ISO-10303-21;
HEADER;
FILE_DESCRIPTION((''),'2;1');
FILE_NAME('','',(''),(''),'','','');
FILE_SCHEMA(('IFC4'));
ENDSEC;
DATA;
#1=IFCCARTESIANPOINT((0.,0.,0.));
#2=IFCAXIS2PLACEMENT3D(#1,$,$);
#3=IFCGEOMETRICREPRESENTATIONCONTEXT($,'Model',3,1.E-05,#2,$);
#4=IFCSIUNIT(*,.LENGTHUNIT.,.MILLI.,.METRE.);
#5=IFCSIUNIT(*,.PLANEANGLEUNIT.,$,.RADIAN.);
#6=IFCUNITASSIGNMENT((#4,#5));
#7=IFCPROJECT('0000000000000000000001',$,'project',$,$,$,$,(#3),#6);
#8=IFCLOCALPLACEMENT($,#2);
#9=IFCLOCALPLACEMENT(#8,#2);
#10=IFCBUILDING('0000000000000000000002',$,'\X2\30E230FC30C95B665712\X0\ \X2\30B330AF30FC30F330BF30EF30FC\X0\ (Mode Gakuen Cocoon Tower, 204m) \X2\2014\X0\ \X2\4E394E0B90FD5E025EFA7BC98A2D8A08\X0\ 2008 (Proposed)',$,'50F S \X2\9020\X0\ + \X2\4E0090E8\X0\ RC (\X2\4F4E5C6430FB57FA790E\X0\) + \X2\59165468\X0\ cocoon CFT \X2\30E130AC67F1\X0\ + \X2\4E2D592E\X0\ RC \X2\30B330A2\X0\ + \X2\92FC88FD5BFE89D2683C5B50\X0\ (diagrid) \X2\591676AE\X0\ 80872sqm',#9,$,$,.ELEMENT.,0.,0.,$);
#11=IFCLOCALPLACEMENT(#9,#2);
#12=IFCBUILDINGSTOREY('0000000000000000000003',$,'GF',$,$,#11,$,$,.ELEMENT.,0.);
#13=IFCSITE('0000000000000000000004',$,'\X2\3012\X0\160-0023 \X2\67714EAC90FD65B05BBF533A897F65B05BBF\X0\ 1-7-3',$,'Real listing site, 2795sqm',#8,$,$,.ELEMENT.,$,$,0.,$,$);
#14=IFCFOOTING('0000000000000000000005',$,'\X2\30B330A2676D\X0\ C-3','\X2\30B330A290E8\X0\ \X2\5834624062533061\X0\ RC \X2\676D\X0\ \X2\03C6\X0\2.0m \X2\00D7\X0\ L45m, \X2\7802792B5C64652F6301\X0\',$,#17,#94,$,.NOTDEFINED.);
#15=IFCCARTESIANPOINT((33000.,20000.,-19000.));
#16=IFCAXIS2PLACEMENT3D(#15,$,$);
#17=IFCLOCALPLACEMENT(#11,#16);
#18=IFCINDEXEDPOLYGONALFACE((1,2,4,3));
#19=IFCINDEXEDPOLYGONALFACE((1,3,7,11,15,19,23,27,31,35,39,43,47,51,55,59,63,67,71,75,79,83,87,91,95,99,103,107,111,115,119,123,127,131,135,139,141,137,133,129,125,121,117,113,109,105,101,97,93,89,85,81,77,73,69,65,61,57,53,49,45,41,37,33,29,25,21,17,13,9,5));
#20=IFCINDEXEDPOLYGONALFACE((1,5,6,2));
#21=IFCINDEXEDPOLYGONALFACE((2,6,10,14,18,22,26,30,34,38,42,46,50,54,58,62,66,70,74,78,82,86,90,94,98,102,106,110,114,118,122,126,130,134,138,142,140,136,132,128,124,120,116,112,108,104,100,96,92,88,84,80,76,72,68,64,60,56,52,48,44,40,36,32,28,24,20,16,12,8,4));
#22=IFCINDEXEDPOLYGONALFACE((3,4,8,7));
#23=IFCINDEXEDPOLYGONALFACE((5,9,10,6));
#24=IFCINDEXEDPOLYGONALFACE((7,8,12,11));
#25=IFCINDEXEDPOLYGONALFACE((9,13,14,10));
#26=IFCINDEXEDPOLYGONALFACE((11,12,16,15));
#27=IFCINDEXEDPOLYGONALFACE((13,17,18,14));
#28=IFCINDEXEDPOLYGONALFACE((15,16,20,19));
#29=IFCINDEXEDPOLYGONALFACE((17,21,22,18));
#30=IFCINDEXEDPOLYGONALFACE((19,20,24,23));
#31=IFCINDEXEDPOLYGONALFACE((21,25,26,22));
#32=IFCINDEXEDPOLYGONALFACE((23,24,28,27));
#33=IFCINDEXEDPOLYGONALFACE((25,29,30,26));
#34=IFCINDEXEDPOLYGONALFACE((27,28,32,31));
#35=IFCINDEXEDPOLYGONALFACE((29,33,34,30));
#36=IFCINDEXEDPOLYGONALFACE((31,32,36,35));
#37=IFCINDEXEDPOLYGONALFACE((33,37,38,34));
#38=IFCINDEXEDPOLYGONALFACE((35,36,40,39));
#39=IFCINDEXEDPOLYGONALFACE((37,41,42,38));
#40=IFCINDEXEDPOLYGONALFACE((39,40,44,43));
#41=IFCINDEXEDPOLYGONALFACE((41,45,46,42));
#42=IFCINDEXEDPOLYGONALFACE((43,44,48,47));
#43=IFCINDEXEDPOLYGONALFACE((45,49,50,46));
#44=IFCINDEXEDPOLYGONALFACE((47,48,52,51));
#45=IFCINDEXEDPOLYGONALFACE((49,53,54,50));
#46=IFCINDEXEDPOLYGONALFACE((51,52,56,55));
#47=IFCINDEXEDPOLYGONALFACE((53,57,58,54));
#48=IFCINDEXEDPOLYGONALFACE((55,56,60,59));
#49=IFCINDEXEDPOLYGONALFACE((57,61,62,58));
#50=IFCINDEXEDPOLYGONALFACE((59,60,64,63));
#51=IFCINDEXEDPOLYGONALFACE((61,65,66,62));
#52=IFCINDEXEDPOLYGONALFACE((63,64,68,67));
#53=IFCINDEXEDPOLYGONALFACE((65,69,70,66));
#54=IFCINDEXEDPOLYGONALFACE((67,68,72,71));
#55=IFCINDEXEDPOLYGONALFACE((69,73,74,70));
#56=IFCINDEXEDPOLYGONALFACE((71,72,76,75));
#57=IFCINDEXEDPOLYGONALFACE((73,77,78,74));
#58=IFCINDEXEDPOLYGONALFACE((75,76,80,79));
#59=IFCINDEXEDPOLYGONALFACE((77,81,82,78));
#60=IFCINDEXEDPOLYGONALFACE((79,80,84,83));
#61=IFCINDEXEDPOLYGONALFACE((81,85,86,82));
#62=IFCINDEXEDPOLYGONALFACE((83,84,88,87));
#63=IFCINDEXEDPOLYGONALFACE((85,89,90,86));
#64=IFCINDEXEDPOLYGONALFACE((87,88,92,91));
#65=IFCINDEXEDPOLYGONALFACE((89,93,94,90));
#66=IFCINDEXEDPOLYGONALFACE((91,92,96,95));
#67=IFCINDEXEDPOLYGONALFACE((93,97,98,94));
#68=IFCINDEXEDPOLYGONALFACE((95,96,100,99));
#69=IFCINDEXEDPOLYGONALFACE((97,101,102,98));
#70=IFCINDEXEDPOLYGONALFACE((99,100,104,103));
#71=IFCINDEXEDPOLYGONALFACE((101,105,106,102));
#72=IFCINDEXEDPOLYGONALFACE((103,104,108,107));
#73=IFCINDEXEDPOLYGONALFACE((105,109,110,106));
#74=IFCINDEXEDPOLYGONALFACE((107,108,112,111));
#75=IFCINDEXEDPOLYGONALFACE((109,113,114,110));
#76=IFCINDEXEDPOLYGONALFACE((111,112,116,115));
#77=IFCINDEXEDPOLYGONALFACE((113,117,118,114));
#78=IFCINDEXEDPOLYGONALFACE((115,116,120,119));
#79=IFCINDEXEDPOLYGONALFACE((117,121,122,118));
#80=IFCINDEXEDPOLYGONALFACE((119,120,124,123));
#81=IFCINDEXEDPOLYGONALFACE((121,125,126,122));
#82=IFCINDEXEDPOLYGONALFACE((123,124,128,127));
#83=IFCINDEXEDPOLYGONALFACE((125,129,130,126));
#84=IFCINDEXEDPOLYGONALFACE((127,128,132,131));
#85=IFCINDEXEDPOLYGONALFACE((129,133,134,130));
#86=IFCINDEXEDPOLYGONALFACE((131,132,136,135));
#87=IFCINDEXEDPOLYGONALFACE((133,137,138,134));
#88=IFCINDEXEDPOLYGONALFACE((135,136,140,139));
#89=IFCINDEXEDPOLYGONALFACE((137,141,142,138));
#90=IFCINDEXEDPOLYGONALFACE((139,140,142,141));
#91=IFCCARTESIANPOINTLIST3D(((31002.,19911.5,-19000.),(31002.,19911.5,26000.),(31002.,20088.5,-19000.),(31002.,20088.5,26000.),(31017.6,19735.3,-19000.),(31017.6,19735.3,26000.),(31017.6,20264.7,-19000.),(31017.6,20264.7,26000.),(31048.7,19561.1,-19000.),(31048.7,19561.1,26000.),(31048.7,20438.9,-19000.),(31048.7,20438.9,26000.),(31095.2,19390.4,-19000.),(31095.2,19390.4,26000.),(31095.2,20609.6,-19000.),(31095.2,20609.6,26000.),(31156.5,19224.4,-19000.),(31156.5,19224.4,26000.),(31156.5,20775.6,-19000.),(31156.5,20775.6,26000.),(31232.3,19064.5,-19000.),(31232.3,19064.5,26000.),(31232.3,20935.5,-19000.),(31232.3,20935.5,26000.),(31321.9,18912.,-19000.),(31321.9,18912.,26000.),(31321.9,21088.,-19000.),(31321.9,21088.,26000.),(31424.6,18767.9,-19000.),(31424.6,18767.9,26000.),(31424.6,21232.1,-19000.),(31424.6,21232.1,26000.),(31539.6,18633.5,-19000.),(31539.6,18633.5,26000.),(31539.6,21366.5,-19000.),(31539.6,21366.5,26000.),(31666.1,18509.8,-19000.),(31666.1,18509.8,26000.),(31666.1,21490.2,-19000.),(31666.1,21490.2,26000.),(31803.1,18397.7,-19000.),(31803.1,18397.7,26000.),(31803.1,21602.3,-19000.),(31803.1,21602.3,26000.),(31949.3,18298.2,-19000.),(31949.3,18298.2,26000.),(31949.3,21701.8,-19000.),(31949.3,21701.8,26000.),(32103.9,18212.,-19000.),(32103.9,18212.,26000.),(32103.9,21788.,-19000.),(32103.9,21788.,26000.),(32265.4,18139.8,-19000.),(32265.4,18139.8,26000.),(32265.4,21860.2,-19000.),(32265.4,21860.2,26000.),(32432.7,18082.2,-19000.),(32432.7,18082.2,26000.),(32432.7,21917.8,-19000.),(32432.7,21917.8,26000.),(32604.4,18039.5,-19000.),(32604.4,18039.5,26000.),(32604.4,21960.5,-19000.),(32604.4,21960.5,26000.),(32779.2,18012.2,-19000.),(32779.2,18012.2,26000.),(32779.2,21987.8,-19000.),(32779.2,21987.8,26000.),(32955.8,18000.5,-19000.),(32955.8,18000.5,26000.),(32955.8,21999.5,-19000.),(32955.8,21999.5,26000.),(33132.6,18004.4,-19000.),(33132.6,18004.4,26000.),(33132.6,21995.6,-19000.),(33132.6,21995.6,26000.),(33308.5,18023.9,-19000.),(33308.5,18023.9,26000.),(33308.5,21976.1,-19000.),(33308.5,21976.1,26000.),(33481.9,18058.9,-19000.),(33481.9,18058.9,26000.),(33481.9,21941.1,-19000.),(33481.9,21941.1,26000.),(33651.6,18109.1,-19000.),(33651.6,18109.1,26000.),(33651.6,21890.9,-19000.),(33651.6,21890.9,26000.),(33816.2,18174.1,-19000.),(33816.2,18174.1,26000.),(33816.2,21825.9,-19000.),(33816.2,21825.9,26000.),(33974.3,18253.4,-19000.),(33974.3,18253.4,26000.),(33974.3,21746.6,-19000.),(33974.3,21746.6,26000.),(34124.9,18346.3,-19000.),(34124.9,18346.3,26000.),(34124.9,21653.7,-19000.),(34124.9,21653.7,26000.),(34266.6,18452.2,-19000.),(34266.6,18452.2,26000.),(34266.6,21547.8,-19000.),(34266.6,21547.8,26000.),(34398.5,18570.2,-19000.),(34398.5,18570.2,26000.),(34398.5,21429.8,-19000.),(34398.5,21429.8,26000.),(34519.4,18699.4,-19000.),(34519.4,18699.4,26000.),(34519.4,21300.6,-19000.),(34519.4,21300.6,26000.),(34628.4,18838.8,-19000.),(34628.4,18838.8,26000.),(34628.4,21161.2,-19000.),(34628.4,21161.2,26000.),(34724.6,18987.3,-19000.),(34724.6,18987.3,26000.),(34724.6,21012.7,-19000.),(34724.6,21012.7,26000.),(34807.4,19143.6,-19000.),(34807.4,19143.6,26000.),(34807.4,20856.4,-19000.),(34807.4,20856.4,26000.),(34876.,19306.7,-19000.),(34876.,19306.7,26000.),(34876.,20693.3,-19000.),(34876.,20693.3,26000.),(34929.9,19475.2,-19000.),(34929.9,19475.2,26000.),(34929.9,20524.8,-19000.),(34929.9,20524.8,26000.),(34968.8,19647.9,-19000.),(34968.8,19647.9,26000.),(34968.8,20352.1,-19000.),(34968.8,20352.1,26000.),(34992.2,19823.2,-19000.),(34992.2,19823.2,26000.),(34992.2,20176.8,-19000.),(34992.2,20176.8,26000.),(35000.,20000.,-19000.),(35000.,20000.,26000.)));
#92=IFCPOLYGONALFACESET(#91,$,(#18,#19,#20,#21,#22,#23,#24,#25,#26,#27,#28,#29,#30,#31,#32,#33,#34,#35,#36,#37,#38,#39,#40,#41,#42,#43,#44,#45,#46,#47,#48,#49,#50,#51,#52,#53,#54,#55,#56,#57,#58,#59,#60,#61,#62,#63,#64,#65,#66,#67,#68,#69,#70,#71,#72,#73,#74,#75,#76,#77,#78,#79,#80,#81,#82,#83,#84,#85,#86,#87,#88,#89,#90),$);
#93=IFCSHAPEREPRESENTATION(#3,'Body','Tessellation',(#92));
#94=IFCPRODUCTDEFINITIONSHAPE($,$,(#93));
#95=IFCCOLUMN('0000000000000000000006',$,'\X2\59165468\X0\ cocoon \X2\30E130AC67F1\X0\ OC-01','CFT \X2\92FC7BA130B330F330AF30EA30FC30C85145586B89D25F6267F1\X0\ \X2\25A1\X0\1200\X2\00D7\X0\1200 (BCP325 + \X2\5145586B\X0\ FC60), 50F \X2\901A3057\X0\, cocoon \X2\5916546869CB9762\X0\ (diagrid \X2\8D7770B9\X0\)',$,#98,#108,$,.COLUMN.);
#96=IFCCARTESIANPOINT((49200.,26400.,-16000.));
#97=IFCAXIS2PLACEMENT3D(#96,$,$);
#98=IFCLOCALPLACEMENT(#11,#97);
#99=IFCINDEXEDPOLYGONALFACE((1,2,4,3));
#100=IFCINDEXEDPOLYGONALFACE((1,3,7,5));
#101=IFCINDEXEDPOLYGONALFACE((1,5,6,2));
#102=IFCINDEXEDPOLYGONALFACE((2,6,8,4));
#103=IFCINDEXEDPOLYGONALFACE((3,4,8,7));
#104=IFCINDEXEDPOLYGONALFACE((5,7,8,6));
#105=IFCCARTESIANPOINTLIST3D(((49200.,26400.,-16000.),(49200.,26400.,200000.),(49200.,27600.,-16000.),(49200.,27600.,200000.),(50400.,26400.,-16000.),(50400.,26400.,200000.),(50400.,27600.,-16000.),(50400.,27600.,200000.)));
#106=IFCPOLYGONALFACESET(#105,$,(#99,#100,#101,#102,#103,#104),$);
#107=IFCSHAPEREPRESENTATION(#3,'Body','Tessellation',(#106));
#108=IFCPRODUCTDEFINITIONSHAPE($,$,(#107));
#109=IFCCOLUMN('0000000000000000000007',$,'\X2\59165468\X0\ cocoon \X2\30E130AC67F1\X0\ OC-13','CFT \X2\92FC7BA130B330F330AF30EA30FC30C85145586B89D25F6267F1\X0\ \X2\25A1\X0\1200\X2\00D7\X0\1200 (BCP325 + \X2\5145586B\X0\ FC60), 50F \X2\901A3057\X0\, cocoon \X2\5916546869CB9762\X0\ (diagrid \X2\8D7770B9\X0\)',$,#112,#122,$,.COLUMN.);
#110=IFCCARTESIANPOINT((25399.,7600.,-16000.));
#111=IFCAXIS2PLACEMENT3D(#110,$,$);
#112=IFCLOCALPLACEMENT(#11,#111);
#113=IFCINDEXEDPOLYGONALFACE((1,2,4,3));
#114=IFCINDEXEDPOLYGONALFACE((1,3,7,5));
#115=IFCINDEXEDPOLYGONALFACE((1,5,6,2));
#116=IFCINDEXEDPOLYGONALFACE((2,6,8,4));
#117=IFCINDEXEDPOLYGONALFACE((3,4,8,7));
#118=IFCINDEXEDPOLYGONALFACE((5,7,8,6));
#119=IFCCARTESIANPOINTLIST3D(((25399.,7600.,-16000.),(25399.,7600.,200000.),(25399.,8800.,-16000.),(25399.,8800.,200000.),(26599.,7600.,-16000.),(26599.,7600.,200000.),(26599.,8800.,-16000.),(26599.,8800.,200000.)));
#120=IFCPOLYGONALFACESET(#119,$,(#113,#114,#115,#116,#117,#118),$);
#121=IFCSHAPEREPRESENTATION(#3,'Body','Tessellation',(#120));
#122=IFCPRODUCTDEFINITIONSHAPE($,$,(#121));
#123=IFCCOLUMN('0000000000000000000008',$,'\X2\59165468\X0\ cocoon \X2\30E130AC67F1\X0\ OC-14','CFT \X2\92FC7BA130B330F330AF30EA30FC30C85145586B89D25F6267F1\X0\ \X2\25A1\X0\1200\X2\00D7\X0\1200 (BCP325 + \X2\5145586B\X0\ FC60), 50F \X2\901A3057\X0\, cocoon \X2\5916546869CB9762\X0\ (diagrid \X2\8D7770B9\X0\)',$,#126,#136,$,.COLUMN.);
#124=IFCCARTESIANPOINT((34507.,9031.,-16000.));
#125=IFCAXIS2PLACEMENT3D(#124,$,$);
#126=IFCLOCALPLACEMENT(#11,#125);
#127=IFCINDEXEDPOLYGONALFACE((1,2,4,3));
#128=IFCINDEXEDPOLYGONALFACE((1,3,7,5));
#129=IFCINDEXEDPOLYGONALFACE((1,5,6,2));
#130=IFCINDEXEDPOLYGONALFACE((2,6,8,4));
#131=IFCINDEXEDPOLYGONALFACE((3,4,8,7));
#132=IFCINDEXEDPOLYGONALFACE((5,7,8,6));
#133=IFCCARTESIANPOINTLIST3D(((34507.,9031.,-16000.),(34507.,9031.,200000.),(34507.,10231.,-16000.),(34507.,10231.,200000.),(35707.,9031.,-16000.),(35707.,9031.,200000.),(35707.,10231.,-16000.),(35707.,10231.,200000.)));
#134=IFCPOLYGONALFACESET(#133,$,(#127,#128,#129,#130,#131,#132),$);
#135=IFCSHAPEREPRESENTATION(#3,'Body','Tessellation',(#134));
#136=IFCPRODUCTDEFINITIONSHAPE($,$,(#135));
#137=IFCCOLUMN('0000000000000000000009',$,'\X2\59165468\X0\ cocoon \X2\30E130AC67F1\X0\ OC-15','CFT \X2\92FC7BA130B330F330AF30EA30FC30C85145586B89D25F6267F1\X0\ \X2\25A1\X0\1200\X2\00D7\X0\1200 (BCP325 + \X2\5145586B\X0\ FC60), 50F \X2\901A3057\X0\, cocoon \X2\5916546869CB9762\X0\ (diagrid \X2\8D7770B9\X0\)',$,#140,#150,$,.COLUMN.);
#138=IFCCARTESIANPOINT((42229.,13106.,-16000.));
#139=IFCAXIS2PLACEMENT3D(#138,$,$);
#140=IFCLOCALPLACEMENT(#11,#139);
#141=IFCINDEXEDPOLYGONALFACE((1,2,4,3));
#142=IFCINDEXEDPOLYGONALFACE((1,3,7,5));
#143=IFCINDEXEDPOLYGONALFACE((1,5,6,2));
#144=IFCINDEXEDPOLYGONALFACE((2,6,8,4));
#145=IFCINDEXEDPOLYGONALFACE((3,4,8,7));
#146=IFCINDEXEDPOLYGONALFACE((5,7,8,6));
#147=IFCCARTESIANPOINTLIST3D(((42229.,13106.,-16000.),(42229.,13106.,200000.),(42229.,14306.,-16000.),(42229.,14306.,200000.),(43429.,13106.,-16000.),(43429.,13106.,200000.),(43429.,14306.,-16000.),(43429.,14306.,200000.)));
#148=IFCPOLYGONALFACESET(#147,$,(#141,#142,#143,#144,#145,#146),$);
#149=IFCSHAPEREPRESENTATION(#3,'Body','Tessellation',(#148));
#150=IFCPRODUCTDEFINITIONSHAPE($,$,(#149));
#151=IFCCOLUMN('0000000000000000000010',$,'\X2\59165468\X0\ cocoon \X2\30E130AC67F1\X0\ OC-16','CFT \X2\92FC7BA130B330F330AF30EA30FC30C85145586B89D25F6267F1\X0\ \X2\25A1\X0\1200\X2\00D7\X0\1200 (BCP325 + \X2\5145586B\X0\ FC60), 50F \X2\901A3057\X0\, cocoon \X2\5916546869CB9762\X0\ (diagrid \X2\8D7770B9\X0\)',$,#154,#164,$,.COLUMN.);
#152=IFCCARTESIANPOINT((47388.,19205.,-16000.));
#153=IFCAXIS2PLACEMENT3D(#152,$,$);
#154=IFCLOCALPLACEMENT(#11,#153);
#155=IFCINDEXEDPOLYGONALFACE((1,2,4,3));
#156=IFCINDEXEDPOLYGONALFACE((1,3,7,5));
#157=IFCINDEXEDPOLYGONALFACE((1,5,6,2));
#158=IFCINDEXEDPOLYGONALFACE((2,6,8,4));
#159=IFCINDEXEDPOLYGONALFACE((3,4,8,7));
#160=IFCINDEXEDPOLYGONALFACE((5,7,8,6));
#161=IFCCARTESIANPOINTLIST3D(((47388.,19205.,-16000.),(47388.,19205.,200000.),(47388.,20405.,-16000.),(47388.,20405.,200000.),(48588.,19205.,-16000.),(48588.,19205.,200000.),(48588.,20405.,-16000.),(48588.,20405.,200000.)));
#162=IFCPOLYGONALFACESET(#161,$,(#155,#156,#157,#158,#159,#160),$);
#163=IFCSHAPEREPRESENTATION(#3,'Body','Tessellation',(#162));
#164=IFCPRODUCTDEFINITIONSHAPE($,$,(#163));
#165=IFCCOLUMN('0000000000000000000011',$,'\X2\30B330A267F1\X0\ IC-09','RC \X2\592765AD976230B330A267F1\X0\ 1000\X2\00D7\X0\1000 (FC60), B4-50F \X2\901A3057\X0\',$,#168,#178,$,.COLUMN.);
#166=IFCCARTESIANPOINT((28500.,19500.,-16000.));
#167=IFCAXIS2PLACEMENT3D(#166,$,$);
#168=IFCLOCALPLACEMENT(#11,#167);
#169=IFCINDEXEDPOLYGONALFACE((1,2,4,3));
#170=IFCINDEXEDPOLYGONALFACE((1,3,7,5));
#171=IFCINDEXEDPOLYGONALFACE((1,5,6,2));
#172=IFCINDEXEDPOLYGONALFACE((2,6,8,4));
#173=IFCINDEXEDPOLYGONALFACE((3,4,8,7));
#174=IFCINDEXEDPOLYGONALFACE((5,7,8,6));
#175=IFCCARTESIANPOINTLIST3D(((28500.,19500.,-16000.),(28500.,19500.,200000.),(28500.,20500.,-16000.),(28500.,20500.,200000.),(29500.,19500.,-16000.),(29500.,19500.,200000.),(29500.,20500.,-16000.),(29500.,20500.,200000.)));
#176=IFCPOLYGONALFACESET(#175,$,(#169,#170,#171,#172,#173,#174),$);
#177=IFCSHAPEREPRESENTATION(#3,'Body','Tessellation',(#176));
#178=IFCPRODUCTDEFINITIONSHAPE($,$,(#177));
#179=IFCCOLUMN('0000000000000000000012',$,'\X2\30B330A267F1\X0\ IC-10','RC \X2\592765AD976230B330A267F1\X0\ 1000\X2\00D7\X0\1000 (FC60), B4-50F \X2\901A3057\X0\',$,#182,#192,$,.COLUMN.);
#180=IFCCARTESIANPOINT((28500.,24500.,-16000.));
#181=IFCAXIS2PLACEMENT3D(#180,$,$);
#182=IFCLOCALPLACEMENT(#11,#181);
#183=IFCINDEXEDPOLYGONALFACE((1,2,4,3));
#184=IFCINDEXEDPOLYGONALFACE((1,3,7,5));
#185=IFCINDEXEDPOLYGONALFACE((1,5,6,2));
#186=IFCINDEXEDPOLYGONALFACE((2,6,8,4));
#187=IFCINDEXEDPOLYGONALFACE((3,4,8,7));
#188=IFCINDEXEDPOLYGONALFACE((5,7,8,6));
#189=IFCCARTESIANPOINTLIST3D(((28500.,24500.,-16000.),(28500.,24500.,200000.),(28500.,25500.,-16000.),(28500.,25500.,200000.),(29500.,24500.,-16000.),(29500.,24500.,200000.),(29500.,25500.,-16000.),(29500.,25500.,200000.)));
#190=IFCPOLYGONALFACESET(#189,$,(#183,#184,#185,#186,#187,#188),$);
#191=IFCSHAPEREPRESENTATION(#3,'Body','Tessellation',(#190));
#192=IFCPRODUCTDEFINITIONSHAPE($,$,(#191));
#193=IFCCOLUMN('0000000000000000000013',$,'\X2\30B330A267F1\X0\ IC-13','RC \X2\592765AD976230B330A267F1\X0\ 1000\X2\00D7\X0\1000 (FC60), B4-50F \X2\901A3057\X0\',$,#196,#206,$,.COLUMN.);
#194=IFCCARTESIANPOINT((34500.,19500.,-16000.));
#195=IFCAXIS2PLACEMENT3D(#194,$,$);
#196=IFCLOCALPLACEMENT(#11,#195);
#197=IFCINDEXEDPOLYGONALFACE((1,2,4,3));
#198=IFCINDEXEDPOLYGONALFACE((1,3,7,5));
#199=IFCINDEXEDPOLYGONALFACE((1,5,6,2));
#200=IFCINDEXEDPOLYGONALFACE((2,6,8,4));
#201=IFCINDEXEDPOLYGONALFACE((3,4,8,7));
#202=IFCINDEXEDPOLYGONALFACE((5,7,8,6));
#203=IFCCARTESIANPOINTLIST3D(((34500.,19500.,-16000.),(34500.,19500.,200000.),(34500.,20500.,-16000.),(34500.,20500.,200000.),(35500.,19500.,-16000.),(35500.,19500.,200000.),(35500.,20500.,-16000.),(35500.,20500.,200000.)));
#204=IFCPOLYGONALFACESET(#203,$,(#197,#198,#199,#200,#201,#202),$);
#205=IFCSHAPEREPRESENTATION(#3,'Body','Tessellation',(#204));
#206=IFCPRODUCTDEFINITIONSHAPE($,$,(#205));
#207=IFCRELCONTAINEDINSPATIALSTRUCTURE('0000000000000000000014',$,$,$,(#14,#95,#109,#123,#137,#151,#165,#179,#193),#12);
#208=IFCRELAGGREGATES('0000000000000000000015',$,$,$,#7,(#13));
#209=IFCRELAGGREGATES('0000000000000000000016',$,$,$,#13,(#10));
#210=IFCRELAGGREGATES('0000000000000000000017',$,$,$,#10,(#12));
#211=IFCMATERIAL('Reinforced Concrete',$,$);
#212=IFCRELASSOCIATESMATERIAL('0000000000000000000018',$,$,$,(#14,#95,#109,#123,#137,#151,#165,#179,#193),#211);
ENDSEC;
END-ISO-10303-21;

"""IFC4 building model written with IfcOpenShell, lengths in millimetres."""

from ifc_helpers import new_model, si_unit, frame, frame_2d, origin, origin_2d, place, context, project, spatial, rectangle, circle, extrude, material, element, save


model = new_model("IFC4")

# Units and contexts
model_context = context("Model", 3, precision=1e-05, world=origin())
ifc_project = project(units=[si_unit("LENGTHUNIT", "METRE", prefix="MILLI"), si_unit("PLANEANGLEUNIT", "RADIAN")], contexts=[model_context])

# Site, building, storey
site_placement = place(None, origin())
site = spatial("IfcSite", under=ifc_project, at=site_placement, Name="〒160-0023 東京都新宿区西新宿 1-7-3", ObjectType="Real listing site, 2795sqm", CompositionType="ELEMENT", RefElevation=0.0)
building_placement = place(site_placement, origin())
building = spatial("IfcBuilding", under=site, at=building_placement, Name="モード学園 コクーンタワー (Mode Gakuen Cocoon Tower, 204m) — 丹下都市建築設計 2008 (Proposed)", ObjectType="50F S 造 + 一部 RC (低層・基礎) + 外周 cocoon CFT メガ柱 + 中央 RC コア + 鋼製対角格子 (diagrid) 外皮 80872sqm", CompositionType="ELEMENT", ElevationOfRefHeight=0.0, ElevationOfTerrain=0.0)
storey_placement = place(building_placement, origin())
storey = spatial("IfcBuildingStorey", under=building, at=storey_placement, Name="GF", CompositionType="ELEMENT", Elevation=0.0)

# Footing
ifc_material_1 = material(Name="Reinforced Concrete")
footing_1_placement = place(storey_placement, frame((33000.0, 20000.0, -19000.0)))
element("IfcFooting", 1, at=footing_1_placement, inside=storey, material=ifc_material_1, Name="コア杭 C-3", Description="コア部 場所打ち RC 杭 φ2.0m × L45m, 砂礫層支持", PredefinedType="NOTDEFINED", context=model_context, shape_type="SweptSolid", body=[
    extrude(circle(Radius=2000.0, at=origin_2d()), frame((33000.0, 20000.0, -19000.0)), (0.0, 0.0, 1.0), 45000.0),
])

# Columns
column_1_placement = place(storey_placement, frame((49200.0, 26400.0, -16000.0)))
element("IfcColumn", 2, at=column_1_placement, inside=storey, material=ifc_material_1, Name="外周 cocoon メガ柱 OC-01", Description="CFT 鋼管コンクリート充填角形柱 □1200×1200 (BCP325 + 充填 FC60), 50F 通し, cocoon 外周構面 (diagrid 起点)", PredefinedType="COLUMN", context=model_context, shape_type="SweptSolid", body=[
    extrude(rectangle(XDim=1200.0, YDim=1200.0, at=frame_2d((600.0, 600.0))), frame((49200.0, 26400.0, -16000.0)), (0.0, 0.0, 1.0), 216000.0),
])
column_2_placement = place(storey_placement, frame((25399.0, 7600.0, -16000.0)))
element("IfcColumn", 3, at=column_2_placement, inside=storey, material=ifc_material_1, Name="外周 cocoon メガ柱 OC-13", Description="CFT 鋼管コンクリート充填角形柱 □1200×1200 (BCP325 + 充填 FC60), 50F 通し, cocoon 外周構面 (diagrid 起点)", PredefinedType="COLUMN", context=model_context, shape_type="SweptSolid", body=[
    extrude(rectangle(XDim=1200.0, YDim=1200.0, at=frame_2d((600.0, 600.0))), frame((25399.0, 7600.0, -16000.0)), (0.0, 0.0, 1.0), 216000.0),
])
column_3_placement = place(storey_placement, frame((34507.0, 9031.0, -16000.0)))
element("IfcColumn", 4, at=column_3_placement, inside=storey, material=ifc_material_1, Name="外周 cocoon メガ柱 OC-14", Description="CFT 鋼管コンクリート充填角形柱 □1200×1200 (BCP325 + 充填 FC60), 50F 通し, cocoon 外周構面 (diagrid 起点)", PredefinedType="COLUMN", context=model_context, shape_type="SweptSolid", body=[
    extrude(rectangle(XDim=1200.0, YDim=1200.0, at=frame_2d((600.0, 600.0))), frame((34507.0, 9031.0, -16000.0)), (0.0, 0.0, 1.0), 216000.0),
])
column_4_placement = place(storey_placement, frame((42229.0, 13106.0, -16000.0)))
element("IfcColumn", 5, at=column_4_placement, inside=storey, material=ifc_material_1, Name="外周 cocoon メガ柱 OC-15", Description="CFT 鋼管コンクリート充填角形柱 □1200×1200 (BCP325 + 充填 FC60), 50F 通し, cocoon 外周構面 (diagrid 起点)", PredefinedType="COLUMN", context=model_context, shape_type="SweptSolid", body=[
    extrude(rectangle(XDim=1200.0, YDim=1200.0, at=frame_2d((600.0, 600.0))), frame((42229.0, 13106.0, -16000.0)), (0.0, 0.0, 1.0), 216000.0),
])
column_5_placement = place(storey_placement, frame((47388.0, 19205.0, -16000.0)))
element("IfcColumn", 6, at=column_5_placement, inside=storey, material=ifc_material_1, Name="外周 cocoon メガ柱 OC-16", Description="CFT 鋼管コンクリート充填角形柱 □1200×1200 (BCP325 + 充填 FC60), 50F 通し, cocoon 外周構面 (diagrid 起点)", PredefinedType="COLUMN", context=model_context, shape_type="SweptSolid", body=[
    extrude(rectangle(XDim=1200.0, YDim=1200.0, at=frame_2d((600.0, 600.0))), frame((47388.0, 19205.0, -16000.0)), (0.0, 0.0, 1.0), 216000.0),
])
column_6_placement = place(storey_placement, frame((28500.0, 19500.0, -16000.0)))
element("IfcColumn", 7, at=column_6_placement, inside=storey, material=ifc_material_1, Name="コア柱 IC-09", Description="RC 大断面コア柱 1000×1000 (FC60), B4-50F 通し", PredefinedType="COLUMN", context=model_context, shape_type="SweptSolid", body=[
    extrude(rectangle(XDim=1000.0, YDim=1000.0, at=frame_2d((500.0, 500.0))), frame((28500.0, 19500.0, -16000.0)), (0.0, 0.0, 1.0), 216000.0),
])
column_7_placement = place(storey_placement, frame((28500.0, 24500.0, -16000.0)))
element("IfcColumn", 8, at=column_7_placement, inside=storey, material=ifc_material_1, Name="コア柱 IC-10", Description="RC 大断面コア柱 1000×1000 (FC60), B4-50F 通し", PredefinedType="COLUMN", context=model_context, shape_type="SweptSolid", body=[
    extrude(rectangle(XDim=1000.0, YDim=1000.0, at=frame_2d((500.0, 500.0))), frame((28500.0, 24500.0, -16000.0)), (0.0, 0.0, 1.0), 216000.0),
])
column_8_placement = place(storey_placement, frame((34500.0, 19500.0, -16000.0)))
element("IfcColumn", 9, at=column_8_placement, inside=storey, material=ifc_material_1, Name="コア柱 IC-13", Description="RC 大断面コア柱 1000×1000 (FC60), B4-50F 通し", PredefinedType="COLUMN", context=model_context, shape_type="SweptSolid", body=[
    extrude(rectangle(XDim=1000.0, YDim=1000.0, at=frame_2d((500.0, 500.0))), frame((34500.0, 19500.0, -16000.0)), (0.0, 0.0, 1.0), 216000.0),
])

save(model, "model.ifc")
